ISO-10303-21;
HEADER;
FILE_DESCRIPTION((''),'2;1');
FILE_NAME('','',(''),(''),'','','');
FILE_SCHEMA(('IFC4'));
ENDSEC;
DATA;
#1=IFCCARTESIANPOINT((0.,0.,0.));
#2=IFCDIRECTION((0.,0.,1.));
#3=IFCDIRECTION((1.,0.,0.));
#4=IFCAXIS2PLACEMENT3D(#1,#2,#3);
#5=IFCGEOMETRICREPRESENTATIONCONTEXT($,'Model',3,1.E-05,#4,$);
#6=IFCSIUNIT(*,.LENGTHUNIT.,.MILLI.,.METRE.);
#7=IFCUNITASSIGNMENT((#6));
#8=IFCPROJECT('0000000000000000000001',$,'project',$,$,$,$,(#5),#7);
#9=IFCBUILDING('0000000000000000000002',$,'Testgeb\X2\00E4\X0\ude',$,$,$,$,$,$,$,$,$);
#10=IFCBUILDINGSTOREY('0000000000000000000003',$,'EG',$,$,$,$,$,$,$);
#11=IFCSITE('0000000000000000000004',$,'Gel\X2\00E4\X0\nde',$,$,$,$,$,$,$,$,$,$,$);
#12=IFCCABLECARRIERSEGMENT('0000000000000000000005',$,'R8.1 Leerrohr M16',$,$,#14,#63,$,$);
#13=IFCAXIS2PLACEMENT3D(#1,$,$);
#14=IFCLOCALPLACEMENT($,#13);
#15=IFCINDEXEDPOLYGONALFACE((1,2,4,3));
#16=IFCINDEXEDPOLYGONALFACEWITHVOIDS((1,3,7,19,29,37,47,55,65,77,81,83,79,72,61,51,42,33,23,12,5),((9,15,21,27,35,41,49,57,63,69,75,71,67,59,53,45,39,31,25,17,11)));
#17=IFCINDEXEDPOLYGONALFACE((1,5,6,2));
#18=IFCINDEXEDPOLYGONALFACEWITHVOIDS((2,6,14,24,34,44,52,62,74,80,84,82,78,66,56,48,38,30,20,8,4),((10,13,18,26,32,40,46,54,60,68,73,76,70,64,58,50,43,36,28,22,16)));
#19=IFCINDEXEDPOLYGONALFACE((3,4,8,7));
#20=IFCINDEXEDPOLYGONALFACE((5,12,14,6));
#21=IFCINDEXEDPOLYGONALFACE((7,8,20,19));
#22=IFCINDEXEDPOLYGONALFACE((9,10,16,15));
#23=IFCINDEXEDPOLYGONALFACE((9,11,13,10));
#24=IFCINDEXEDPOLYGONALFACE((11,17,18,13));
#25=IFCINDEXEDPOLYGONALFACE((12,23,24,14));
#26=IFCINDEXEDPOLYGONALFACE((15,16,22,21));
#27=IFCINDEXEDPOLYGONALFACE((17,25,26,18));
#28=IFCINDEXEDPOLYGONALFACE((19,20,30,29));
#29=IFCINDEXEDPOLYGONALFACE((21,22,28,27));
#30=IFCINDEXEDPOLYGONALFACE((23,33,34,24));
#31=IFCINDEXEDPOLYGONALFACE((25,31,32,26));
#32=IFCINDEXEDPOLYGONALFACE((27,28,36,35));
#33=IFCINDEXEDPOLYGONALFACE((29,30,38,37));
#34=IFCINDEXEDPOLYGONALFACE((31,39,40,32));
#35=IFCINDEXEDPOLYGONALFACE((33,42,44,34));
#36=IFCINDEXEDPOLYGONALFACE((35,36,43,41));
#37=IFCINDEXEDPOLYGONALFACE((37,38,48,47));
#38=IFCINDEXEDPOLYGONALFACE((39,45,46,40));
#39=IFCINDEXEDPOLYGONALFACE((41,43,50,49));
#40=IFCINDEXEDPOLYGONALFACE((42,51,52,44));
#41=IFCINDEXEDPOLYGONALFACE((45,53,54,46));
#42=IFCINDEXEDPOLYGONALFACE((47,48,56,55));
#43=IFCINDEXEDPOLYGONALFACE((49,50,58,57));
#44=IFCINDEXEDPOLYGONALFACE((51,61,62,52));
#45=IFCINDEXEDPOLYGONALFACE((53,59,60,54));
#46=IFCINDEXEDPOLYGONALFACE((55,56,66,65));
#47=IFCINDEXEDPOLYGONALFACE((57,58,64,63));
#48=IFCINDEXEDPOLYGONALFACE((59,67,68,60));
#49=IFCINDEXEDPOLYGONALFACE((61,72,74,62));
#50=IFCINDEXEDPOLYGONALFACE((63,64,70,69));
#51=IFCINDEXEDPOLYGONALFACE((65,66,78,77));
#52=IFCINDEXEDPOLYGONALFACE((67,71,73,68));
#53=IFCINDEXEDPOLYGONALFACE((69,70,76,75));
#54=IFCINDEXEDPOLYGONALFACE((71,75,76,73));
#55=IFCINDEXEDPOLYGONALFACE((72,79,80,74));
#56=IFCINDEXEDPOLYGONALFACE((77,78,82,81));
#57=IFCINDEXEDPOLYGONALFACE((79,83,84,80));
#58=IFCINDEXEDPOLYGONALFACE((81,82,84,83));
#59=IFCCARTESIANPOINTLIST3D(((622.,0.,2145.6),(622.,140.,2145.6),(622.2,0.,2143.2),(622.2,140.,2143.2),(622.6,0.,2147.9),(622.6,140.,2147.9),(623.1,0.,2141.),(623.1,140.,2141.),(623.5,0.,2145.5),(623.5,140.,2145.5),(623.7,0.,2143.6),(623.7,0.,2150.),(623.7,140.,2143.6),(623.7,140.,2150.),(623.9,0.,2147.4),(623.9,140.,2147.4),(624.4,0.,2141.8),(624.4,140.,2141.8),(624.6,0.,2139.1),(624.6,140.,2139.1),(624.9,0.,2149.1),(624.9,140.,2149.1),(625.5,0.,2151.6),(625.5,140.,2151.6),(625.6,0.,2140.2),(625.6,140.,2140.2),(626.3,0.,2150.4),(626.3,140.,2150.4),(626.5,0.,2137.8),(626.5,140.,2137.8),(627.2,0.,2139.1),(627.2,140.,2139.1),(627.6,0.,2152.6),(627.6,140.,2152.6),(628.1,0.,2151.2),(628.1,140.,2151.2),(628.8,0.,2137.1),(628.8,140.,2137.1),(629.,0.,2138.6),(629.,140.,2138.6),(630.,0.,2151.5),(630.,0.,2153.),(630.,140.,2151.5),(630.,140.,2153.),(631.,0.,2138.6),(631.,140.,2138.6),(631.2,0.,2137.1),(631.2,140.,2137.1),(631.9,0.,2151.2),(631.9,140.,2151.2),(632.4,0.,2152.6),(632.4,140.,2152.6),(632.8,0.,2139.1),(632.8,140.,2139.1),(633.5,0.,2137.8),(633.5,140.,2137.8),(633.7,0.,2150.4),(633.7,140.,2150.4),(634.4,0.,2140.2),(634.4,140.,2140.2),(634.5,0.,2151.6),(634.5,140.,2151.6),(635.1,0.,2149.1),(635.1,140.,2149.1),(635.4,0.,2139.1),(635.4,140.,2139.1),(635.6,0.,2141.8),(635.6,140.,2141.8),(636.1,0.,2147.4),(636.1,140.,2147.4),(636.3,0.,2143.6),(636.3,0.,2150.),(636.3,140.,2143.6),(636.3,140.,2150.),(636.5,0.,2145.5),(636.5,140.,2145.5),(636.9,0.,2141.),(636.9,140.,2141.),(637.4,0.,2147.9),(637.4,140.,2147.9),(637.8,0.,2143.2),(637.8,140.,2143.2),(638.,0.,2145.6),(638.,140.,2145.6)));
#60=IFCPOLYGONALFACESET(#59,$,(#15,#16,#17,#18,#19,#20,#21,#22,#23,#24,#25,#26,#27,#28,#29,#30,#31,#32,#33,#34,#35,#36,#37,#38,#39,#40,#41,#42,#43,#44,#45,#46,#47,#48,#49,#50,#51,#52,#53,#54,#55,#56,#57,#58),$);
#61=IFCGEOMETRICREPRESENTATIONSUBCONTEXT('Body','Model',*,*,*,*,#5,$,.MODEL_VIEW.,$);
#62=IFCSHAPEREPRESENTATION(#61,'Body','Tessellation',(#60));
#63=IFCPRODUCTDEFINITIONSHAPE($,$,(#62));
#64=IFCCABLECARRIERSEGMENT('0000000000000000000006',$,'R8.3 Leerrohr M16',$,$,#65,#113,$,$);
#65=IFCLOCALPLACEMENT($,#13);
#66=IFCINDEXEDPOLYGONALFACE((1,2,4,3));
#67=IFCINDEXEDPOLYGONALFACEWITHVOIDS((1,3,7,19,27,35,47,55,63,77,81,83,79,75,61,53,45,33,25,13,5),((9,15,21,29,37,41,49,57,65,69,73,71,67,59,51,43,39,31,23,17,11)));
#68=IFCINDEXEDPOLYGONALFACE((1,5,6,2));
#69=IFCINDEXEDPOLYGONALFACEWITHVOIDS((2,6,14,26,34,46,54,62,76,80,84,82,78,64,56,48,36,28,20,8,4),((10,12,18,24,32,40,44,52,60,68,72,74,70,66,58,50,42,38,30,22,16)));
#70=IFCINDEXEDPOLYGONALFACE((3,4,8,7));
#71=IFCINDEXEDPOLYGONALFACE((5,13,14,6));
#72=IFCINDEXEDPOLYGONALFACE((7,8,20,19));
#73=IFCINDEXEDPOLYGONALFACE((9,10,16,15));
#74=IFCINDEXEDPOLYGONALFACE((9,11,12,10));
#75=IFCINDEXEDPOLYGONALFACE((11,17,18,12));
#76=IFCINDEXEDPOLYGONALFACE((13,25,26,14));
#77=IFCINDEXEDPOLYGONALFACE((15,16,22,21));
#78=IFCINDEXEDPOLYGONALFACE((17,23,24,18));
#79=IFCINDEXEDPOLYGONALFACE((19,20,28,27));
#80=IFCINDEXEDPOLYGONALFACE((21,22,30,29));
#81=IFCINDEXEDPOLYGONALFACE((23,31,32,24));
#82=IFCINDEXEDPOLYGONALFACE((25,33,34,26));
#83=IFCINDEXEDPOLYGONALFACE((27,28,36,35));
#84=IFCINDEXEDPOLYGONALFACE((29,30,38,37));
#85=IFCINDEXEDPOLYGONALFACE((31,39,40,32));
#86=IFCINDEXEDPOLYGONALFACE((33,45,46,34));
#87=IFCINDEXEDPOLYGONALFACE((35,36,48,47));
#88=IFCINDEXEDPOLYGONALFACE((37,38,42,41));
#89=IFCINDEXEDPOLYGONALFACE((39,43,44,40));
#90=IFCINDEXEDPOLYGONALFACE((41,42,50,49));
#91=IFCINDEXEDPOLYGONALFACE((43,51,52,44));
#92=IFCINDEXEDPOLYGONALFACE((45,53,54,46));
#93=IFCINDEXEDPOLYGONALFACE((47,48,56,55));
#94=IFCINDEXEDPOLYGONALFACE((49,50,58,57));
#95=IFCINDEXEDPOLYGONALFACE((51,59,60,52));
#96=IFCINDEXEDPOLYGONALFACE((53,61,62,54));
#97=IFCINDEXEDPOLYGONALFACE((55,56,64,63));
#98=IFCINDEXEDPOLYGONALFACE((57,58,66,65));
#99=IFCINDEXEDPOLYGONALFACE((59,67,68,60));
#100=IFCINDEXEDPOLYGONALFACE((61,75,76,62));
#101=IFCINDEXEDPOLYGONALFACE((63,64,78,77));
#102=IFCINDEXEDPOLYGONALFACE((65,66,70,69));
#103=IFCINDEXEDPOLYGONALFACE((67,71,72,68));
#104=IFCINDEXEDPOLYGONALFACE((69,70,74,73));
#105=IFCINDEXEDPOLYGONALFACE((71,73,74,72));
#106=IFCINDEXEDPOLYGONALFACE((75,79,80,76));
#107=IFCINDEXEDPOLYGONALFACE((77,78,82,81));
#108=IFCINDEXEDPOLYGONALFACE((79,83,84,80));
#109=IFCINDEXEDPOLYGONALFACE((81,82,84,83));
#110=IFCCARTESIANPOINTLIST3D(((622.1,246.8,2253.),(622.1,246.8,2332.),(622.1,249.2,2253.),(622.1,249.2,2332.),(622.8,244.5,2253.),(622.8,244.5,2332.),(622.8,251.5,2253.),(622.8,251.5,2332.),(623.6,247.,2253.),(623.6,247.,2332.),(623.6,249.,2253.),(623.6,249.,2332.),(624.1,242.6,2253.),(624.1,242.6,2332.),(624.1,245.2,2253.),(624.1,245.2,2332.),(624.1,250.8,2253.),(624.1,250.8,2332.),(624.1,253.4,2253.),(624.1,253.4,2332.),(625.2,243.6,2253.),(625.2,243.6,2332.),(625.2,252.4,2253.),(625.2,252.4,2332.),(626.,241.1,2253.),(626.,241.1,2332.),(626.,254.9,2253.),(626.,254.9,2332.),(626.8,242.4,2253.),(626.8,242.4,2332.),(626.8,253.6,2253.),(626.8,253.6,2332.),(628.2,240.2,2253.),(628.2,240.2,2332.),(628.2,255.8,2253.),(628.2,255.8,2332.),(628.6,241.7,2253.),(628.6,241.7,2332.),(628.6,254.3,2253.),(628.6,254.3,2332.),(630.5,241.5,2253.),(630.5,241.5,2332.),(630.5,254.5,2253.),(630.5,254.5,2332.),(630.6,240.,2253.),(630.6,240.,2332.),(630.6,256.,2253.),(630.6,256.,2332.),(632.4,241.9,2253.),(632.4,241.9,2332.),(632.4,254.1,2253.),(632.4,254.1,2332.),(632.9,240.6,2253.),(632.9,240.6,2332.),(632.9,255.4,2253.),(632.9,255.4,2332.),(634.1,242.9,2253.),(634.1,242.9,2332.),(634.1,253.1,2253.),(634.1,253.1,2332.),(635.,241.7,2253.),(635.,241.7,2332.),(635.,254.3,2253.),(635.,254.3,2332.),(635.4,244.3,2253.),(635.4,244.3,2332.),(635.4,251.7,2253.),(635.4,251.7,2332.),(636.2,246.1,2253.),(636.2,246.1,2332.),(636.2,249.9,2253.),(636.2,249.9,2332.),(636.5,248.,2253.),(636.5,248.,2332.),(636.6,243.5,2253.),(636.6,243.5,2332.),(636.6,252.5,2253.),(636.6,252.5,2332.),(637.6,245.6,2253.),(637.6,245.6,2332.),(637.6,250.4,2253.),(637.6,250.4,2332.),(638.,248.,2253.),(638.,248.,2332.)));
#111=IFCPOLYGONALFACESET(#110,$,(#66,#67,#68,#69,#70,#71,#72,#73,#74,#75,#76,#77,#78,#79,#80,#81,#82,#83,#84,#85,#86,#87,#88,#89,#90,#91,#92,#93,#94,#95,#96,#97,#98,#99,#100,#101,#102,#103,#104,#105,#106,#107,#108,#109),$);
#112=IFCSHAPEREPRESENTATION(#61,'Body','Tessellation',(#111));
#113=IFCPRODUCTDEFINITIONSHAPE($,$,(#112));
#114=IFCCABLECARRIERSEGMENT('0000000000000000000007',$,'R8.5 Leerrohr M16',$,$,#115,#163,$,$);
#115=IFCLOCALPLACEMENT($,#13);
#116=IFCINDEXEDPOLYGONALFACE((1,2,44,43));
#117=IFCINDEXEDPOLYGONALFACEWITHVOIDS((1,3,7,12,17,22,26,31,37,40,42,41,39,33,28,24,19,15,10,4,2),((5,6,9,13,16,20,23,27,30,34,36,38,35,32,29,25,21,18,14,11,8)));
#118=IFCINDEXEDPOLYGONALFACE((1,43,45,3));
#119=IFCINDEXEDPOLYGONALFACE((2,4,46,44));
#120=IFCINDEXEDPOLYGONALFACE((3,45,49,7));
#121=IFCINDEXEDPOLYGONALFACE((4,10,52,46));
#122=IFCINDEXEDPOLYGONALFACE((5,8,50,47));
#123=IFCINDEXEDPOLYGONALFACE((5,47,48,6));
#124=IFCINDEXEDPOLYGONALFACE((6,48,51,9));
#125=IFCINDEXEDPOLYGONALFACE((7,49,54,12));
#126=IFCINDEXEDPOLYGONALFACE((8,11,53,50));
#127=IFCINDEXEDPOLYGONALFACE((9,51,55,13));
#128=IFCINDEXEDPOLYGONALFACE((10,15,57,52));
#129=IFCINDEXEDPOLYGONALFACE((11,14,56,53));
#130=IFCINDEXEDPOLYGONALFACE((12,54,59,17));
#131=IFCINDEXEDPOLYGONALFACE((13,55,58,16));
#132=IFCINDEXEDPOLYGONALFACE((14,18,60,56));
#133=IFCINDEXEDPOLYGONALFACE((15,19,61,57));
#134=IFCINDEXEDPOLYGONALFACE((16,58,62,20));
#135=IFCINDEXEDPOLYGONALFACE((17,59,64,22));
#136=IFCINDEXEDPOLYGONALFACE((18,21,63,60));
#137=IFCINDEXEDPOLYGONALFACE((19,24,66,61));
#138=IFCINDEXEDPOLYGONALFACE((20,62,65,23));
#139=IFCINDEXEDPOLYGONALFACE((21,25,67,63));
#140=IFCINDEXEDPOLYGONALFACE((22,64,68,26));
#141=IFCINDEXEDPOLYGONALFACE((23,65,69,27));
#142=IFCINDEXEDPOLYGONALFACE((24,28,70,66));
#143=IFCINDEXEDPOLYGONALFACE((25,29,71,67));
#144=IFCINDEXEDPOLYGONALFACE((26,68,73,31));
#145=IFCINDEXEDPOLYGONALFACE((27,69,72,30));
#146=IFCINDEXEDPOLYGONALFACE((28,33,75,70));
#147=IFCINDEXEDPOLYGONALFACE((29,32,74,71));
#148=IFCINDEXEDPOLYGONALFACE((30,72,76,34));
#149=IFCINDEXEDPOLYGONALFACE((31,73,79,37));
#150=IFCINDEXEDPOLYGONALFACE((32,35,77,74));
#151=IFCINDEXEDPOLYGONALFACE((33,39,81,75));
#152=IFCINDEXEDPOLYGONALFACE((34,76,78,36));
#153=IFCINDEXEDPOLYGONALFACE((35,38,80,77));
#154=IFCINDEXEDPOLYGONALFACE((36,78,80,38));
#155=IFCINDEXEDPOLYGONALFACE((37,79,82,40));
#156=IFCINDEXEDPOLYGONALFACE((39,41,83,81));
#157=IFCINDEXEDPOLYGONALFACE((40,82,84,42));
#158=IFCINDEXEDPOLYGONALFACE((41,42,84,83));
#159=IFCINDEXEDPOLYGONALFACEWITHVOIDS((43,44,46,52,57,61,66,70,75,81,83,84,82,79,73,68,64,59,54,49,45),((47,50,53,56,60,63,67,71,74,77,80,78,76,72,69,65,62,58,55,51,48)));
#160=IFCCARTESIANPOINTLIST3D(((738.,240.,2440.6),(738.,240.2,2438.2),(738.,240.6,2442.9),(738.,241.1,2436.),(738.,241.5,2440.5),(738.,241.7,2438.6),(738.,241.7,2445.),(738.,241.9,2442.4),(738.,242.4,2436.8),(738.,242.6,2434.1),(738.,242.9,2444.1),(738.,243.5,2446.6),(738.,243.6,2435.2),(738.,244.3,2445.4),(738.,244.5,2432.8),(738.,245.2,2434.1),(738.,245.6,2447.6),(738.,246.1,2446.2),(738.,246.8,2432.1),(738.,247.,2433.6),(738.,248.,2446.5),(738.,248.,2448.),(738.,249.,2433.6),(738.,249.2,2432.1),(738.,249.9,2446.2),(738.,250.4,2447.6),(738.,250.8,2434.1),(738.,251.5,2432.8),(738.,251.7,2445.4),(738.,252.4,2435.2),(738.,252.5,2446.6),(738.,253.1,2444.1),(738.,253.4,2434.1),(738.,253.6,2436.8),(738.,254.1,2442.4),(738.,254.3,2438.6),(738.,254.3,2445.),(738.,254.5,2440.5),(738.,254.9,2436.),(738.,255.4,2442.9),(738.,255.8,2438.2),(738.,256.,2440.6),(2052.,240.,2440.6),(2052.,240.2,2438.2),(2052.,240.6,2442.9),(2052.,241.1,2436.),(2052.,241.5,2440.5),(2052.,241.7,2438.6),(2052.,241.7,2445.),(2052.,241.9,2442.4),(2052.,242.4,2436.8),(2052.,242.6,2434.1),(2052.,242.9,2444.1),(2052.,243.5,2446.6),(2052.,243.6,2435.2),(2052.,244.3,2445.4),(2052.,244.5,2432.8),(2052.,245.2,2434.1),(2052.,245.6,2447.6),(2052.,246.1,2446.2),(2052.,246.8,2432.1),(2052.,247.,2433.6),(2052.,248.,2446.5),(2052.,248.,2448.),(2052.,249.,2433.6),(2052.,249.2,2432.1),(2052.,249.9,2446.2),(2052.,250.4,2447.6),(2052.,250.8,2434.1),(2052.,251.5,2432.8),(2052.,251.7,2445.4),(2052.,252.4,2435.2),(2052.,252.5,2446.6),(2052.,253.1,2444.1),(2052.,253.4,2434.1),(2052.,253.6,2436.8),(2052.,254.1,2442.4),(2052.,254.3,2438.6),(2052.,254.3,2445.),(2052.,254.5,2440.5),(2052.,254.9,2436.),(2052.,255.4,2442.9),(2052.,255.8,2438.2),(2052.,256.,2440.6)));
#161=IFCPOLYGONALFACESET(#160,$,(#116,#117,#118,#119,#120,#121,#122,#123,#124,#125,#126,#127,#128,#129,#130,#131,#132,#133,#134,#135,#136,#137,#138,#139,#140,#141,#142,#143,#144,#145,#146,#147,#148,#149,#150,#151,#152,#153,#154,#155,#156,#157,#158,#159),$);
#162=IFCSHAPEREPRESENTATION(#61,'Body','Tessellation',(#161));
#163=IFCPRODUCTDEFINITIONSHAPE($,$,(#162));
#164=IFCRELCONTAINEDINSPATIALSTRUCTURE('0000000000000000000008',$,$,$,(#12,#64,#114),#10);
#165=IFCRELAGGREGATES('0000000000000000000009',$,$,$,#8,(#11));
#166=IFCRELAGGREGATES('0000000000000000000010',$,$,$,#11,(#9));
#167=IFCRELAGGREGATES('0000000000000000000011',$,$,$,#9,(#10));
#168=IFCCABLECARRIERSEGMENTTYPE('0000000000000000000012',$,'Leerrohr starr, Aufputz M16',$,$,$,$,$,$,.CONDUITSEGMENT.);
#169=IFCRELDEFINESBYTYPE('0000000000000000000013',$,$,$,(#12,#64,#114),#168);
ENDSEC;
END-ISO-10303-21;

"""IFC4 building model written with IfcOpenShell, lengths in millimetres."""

from ifc_helpers import new_model, si_unit, frame, origin_with_axes, place, context, subcontext, project, spatial, hollow_circle, extrude, type_object, element, save


model = new_model("IFC4")

# Units and contexts
model_context = context("Model", 3, precision=1e-05, world=origin_with_axes())
body_context = subcontext(model_context, "Body", "Model", "MODEL_VIEW")
ifc_project = project(units=[si_unit("LENGTHUNIT", "METRE", prefix="MILLI")], contexts=[model_context])

# Site, building, storey
site = spatial("IfcSite", under=ifc_project, Name="Gelände")
building = spatial("IfcBuilding", under=site, Name="Testgebäude")
storey = spatial("IfcBuildingStorey", under=building, Name="EG")

# Cable carrier segments
cable_carrier_segment_type_1 = type_object("IfcCableCarrierSegmentType", Name="Leerrohr starr, Aufputz M16", PredefinedType="CONDUITSEGMENT")
cable_carrier_segment_1_placement = place(None, frame((630.0, 0.0, 2145.0), z_axis=(0.0, 1.0, 0.0), x_axis=(0.0, 0.0, 1.0)))
element("IfcCableCarrierSegment", 1, at=cable_carrier_segment_1_placement, inside=storey, type_object=cable_carrier_segment_type_1, Name="R8.1 Leerrohr M16", context=body_context, shape_type="SweptSolid", body=[
    extrude(hollow_circle(Radius=8.0, WallThickness=1.5), None, (0.0, 0.0, 1.0), 140.0),
])
cable_carrier_segment_2_placement = place(None, frame((630.0, 248.0, 2253.0), z_axis=(0.0, 0.0, 1.0), x_axis=(1.0, 0.0, 0.0)))
element("IfcCableCarrierSegment", 2, at=cable_carrier_segment_2_placement, inside=storey, type_object=cable_carrier_segment_type_1, Name="R8.3 Leerrohr M16", context=body_context, shape_type="SweptSolid", body=[
    extrude(hollow_circle(Radius=8.0, WallThickness=1.5), None, (0.0, 0.0, 1.0), 79.0),
])
cable_carrier_segment_3_placement = place(None, frame((738.0, 248.0, 2440.0), z_axis=(1.0, 0.0, 0.0), x_axis=(0.0, 0.0, 1.0)))
element("IfcCableCarrierSegment", 3, at=cable_carrier_segment_3_placement, inside=storey, type_object=cable_carrier_segment_type_1, Name="R8.5 Leerrohr M16", context=body_context, shape_type="SweptSolid", body=[
    extrude(hollow_circle(Radius=8.0, WallThickness=1.5), None, (0.0, 0.0, 1.0), 1314.0),
])

save(model, "model.ifc")
